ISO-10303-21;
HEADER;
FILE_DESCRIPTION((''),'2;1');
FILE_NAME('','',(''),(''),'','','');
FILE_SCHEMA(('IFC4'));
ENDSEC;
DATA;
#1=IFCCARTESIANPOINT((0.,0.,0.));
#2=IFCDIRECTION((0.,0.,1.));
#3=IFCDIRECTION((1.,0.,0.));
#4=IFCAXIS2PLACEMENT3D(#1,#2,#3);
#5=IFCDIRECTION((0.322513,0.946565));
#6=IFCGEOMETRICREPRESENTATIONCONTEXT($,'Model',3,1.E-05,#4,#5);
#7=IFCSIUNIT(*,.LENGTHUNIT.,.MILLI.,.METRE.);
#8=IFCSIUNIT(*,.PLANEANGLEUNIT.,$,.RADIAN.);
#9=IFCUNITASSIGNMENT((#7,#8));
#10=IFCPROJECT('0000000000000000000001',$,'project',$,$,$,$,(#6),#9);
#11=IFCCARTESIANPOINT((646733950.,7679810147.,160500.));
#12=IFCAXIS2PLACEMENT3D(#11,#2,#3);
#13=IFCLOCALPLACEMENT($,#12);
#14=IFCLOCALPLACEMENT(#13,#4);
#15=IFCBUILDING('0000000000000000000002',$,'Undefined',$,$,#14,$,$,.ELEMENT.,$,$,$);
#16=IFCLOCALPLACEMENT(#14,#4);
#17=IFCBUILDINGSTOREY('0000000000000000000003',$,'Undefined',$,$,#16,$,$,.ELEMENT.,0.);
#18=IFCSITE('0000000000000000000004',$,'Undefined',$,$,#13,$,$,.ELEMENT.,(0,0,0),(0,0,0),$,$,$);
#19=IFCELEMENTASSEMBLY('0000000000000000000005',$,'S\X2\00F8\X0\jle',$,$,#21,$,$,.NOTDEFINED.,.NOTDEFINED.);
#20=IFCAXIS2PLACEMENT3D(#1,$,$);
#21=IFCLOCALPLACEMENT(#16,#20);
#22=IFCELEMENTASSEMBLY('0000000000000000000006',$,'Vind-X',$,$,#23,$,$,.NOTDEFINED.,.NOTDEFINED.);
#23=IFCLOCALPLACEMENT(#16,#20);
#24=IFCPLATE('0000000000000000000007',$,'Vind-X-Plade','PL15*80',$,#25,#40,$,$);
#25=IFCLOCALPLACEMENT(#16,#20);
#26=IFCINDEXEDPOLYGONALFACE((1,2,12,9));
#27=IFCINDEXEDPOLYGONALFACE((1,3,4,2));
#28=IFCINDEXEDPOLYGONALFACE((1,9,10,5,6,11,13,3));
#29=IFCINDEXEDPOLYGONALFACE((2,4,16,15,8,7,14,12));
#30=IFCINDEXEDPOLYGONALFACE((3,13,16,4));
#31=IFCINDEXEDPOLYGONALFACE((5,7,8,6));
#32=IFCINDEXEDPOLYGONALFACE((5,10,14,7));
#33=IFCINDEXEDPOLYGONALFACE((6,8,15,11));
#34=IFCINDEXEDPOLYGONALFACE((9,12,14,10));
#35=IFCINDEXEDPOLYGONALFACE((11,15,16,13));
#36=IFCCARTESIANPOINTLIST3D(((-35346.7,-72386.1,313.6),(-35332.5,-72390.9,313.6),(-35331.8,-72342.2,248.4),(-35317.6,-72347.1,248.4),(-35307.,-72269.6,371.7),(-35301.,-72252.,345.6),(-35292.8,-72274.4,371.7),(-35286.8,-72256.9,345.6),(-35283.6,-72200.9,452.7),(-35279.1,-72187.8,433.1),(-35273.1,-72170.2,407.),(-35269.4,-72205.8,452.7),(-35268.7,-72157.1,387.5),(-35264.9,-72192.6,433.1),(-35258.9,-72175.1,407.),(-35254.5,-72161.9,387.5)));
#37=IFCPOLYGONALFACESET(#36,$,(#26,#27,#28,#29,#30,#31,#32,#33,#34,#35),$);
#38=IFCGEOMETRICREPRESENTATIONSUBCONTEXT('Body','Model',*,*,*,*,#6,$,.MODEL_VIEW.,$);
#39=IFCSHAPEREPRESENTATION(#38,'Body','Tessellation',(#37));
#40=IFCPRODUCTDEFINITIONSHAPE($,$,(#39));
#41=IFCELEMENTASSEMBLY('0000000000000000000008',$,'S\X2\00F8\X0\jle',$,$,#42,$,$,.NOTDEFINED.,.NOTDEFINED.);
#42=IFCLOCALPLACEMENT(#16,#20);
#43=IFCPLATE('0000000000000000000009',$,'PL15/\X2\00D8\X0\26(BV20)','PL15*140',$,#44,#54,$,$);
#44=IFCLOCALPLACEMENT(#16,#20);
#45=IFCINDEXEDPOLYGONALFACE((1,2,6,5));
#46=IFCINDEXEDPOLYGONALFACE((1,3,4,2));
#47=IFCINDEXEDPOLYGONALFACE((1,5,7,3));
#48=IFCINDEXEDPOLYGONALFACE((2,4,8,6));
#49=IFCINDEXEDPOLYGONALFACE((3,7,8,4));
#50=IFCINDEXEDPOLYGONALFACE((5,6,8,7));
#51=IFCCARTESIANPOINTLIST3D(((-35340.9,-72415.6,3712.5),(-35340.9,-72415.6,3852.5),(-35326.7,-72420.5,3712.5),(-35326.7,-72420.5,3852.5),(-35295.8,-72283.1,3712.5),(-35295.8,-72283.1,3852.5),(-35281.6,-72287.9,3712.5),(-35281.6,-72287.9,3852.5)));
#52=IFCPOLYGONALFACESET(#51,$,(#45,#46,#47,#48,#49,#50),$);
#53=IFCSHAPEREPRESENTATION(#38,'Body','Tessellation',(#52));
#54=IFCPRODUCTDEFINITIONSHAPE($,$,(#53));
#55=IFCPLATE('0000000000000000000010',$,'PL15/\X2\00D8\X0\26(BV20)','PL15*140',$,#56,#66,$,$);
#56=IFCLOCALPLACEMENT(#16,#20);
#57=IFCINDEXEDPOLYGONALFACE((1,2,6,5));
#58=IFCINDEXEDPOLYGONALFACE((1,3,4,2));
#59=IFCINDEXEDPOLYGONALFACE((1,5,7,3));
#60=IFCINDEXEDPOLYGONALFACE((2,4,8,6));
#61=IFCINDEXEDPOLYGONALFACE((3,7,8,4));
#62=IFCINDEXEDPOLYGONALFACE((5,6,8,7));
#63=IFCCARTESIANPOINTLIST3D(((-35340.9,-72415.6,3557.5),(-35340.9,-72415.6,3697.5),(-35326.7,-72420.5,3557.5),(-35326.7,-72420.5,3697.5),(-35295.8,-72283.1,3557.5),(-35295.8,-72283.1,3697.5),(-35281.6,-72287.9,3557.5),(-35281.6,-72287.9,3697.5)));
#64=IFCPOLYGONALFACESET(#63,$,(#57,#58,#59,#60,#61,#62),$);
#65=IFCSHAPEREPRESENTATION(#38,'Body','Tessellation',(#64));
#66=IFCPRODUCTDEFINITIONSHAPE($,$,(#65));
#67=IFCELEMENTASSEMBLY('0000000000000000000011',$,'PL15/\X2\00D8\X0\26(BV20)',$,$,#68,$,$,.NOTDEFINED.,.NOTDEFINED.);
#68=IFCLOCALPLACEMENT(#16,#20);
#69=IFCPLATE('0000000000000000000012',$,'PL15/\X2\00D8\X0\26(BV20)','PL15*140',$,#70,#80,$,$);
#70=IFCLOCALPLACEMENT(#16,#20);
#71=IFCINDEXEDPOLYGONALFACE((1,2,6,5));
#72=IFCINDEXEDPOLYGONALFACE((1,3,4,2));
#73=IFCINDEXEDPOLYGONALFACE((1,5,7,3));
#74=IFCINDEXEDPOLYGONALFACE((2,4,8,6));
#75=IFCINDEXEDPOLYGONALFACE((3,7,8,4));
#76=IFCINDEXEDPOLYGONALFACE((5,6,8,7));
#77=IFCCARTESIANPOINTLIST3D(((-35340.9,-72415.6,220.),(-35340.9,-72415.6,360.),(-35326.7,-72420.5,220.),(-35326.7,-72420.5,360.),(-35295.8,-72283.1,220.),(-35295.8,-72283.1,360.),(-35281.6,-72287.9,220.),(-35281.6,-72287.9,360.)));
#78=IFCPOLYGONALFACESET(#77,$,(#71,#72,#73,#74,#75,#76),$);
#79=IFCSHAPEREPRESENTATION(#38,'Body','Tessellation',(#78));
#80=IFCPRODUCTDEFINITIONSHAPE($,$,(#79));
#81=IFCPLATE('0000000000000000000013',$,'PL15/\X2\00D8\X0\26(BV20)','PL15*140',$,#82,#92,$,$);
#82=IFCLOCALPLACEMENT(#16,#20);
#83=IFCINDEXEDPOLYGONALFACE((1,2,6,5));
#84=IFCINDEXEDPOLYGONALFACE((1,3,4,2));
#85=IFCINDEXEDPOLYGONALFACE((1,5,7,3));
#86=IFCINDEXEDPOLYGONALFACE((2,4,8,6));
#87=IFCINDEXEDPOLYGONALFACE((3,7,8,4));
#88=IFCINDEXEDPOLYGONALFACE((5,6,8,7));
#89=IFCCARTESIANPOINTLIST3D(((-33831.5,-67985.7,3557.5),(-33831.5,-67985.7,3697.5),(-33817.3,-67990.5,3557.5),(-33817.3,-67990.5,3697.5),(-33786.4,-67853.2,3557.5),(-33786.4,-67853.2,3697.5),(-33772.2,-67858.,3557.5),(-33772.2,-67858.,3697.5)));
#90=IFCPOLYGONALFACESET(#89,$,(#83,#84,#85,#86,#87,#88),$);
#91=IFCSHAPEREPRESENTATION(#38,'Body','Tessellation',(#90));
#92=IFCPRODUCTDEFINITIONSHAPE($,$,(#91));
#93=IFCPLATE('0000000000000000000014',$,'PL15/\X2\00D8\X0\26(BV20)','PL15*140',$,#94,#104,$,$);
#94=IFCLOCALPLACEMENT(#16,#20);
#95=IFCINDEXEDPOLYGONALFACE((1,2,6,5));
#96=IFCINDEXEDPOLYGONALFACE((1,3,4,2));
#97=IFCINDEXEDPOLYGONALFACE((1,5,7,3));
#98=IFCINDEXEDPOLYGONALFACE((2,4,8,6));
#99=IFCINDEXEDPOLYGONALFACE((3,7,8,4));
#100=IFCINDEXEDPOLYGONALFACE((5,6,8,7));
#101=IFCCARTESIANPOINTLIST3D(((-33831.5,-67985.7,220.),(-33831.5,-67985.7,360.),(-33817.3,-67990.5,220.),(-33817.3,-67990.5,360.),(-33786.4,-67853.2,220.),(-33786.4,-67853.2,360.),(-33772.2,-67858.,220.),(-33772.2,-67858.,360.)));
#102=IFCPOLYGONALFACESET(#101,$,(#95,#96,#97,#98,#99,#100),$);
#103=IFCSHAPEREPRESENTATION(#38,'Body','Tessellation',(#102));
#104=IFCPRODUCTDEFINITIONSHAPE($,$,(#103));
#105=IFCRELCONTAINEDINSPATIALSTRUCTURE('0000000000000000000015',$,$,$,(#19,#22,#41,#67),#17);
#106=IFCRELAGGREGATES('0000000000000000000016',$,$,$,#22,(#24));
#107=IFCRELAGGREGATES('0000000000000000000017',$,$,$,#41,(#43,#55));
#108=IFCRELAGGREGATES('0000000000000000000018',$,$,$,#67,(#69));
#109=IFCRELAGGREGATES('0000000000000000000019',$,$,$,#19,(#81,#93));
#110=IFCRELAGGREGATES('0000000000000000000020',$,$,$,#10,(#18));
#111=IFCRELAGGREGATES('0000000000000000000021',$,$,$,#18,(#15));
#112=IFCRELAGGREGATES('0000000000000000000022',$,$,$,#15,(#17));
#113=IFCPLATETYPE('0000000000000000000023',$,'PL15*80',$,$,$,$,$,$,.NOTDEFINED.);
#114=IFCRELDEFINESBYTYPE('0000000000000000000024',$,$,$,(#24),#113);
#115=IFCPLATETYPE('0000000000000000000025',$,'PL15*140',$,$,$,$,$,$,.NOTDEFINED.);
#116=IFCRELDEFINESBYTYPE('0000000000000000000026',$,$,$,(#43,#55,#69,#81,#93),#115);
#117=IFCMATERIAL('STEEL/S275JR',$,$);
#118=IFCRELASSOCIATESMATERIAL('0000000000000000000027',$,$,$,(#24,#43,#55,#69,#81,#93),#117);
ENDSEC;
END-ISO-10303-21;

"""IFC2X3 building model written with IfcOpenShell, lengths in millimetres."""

from ifc_helpers import new_model, si_unit, direction, frame, origin_with_axes, place, context, subcontext, project, spatial, polyline, outline, extrude, boolean, material, type_object, element, aggregate, save


model = new_model("IFC2X3")

# Units and contexts
model_context = context("Model", 3, precision=1e-05, world=origin_with_axes(), true_north=direction((0.322513, 0.946565)))
body_context = subcontext(model_context, "Body", "Model", "MODEL_VIEW")
ifc_project = project(units=[si_unit("LENGTHUNIT", "METRE", prefix="MILLI"), si_unit("PLANEANGLEUNIT", "RADIAN")], contexts=[model_context])

# Site, building, storey
site_placement = place(None, frame((646733950.0, 7679810147.0, 160500.0), z_axis=(0.0, 0.0, 1.0), x_axis=(1.0, 0.0, 0.0)))
site = spatial("IfcSite", under=ifc_project, at=site_placement, Name="Undefined", CompositionType="ELEMENT", RefLatitude=(0, 0, 0), RefLongitude=(0, 0, 0))
building_placement = place(site_placement, origin_with_axes())
building = spatial("IfcBuilding", under=site, at=building_placement, Name="Undefined", CompositionType="ELEMENT")
storey_placement = place(building_placement, origin_with_axes())
storey = spatial("IfcBuildingStorey", under=building, at=storey_placement, Name="Undefined", CompositionType="ELEMENT", Elevation=0.0)

# Element assembly
assembly_1_placement = place(storey_placement, origin_with_axes())
assembly_1 = element("IfcElementAssembly", 1, at=assembly_1_placement, inside=storey, Name="Søjle", AssemblyPlace="NOTDEFINED", PredefinedType="NOTDEFINED")

# Element assembly
assembly_2_placement = place(storey_placement, origin_with_axes())
assembly_2 = element("IfcElementAssembly", 2, at=assembly_2_placement, inside=storey, Name="Vind-X", AssemblyPlace="NOTDEFINED", PredefinedType="NOTDEFINED")

# Shared definitions
ifc_material_1 = material(Name="STEEL/S275JR")

# Plate
plate_type_1 = type_object("IfcPlateType", Name="PL15*80", PredefinedType="NOTDEFINED")
plate_1_placement = place(assembly_2_placement, frame((-35324.7, -72344.7, 248.4), z_axis=(-0.946565, 0.322513, 0.0), x_axis=(-0.186827, -0.54833, 0.815126)))
plate_1 = element("IfcPlate", 3, at=plate_1_placement, type_object=plate_type_1, material=ifc_material_1, Name="Vind-X-Plade", Description="PL15*80", context=body_context, shape_type="CSG", body=[
    boolean("DIFFERENCE", extrude(outline(polyline([(0.0, 0.0), (80.0, 0.0), (80.0, 240.0), (0.0, 240.0), (0.0, 0.0)])), frame((0.0, 0.0, -7.5), z_axis=(0.0, 0.0, 1.0), x_axis=(1.0, 0.0, 0.0)), (0.0, 0.0, 1.0), 15.0), extrude(outline(polyline([(0.0, 0.0), (106.0, 0.0), (106.0, 32.0), (0.0, 32.0), (0.0, 0.0)])), frame((56.0, 240.0, 8.5), z_axis=(0.0, 0.0, -1.0), x_axis=(0.0, -1.0, 0.0)), (0.0, 0.0, 1.0), 17.0)),
])

# Element assembly, plates
assembly_3_placement = place(storey_placement, origin_with_axes())
assembly_3 = element("IfcElementAssembly", 4, at=assembly_3_placement, inside=storey, Name="Søjle", AssemblyPlace="NOTDEFINED", PredefinedType="NOTDEFINED")
plate_type_2 = type_object("IfcPlateType", Name="PL15*140", PredefinedType="NOTDEFINED")
plate_2_placement = place(assembly_3_placement, frame((-35288.7, -72285.5, 3712.5), z_axis=(-0.946565, 0.322513, 0.0), x_axis=(-0.322513, -0.946565, 0.0)))
plate_2 = element("IfcPlate", 5, at=plate_2_placement, type_object=plate_type_2, material=ifc_material_1, Name="PL15/Ø26(BV20)", Description="PL15*140", context=body_context, shape_type="SweptSolid", body=[
    extrude(outline(polyline([(0.0, 0.0), (140.0, 0.0), (140.0, 140.0), (0.0, 140.0), (0.0, 0.0)])), frame((0.0, 0.0, -7.5), z_axis=(0.0, 0.0, 1.0), x_axis=(1.0, 0.0, 0.0)), (0.0, 0.0, 1.0), 15.0),
])
plate_3_placement = place(assembly_3_placement, frame((-35288.7, -72285.5, 3557.5), z_axis=(-0.946565, 0.322513, 0.0), x_axis=(-0.322513, -0.946565, 0.0)))
plate_3 = element("IfcPlate", 6, at=plate_3_placement, type_object=plate_type_2, material=ifc_material_1, Name="PL15/Ø26(BV20)", Description="PL15*140", context=body_context, shape_type="SweptSolid", body=[
    extrude(outline(polyline([(0.0, 0.0), (140.0, 0.0), (140.0, 140.0), (0.0, 140.0), (0.0, 0.0)])), frame((0.0, 0.0, -7.5), z_axis=(0.0, 0.0, 1.0), x_axis=(1.0, 0.0, 0.0)), (0.0, 0.0, 1.0), 15.0),
])

# Element assembly, plate
assembly_4_placement = place(storey_placement, origin_with_axes())
assembly_4 = element("IfcElementAssembly", 7, at=assembly_4_placement, inside=storey, Name="PL15/Ø26(BV20)", AssemblyPlace="NOTDEFINED", PredefinedType="NOTDEFINED")
plate_4_placement = place(assembly_4_placement, frame((-35288.7, -72285.5, 220.0), z_axis=(-0.946565, 0.322513, 0.0), x_axis=(-0.322513, -0.946565, 0.0)))
plate_4 = element("IfcPlate", 8, at=plate_4_placement, type_object=plate_type_2, material=ifc_material_1, Name="PL15/Ø26(BV20)", Description="PL15*140", context=body_context, shape_type="SweptSolid", body=[
    extrude(outline(polyline([(0.0, 0.0), (140.0, 0.0), (140.0, 140.0), (0.0, 140.0), (0.0, 0.0)])), frame((0.0, 0.0, -7.5), z_axis=(0.0, 0.0, 1.0), x_axis=(1.0, 0.0, 0.0)), (0.0, 0.0, 1.0), 15.0),
])

# Plates
plate_5_placement = place(assembly_1_placement, frame((-33779.3, -67855.6, 3557.5), z_axis=(-0.946565, 0.322513, 0.0), x_axis=(-0.322513, -0.946565, 0.0)))
plate_5 = element("IfcPlate", 9, at=plate_5_placement, type_object=plate_type_2, material=ifc_material_1, Name="PL15/Ø26(BV20)", Description="PL15*140", context=body_context, shape_type="SweptSolid", body=[
    extrude(outline(polyline([(0.0, 0.0), (140.0, 0.0), (140.0, 140.0), (0.0, 140.0), (0.0, 0.0)])), frame((0.0, 0.0, -7.5), z_axis=(0.0, 0.0, 1.0), x_axis=(1.0, 0.0, 0.0)), (0.0, 0.0, 1.0), 15.0),
])
plate_6_placement = place(assembly_1_placement, frame((-33779.3, -67855.6, 220.0), z_axis=(-0.946565, 0.322513, 0.0), x_axis=(-0.322513, -0.946565, 0.0)))
plate_6 = element("IfcPlate", 10, at=plate_6_placement, type_object=plate_type_2, material=ifc_material_1, Name="PL15/Ø26(BV20)", Description="PL15*140", context=body_context, shape_type="SweptSolid", body=[
    extrude(outline(polyline([(0.0, 0.0), (140.0, 0.0), (140.0, 140.0), (0.0, 140.0), (0.0, 0.0)])), frame((0.0, 0.0, -7.5), z_axis=(0.0, 0.0, 1.0), x_axis=(1.0, 0.0, 0.0)), (0.0, 0.0, 1.0), 15.0),
])

aggregate(assembly_2, [plate_1])
aggregate(assembly_3, [plate_2, plate_3])
aggregate(assembly_4, [plate_4])
aggregate(assembly_1, [plate_5, plate_6])

save(model, "model.ifc")
